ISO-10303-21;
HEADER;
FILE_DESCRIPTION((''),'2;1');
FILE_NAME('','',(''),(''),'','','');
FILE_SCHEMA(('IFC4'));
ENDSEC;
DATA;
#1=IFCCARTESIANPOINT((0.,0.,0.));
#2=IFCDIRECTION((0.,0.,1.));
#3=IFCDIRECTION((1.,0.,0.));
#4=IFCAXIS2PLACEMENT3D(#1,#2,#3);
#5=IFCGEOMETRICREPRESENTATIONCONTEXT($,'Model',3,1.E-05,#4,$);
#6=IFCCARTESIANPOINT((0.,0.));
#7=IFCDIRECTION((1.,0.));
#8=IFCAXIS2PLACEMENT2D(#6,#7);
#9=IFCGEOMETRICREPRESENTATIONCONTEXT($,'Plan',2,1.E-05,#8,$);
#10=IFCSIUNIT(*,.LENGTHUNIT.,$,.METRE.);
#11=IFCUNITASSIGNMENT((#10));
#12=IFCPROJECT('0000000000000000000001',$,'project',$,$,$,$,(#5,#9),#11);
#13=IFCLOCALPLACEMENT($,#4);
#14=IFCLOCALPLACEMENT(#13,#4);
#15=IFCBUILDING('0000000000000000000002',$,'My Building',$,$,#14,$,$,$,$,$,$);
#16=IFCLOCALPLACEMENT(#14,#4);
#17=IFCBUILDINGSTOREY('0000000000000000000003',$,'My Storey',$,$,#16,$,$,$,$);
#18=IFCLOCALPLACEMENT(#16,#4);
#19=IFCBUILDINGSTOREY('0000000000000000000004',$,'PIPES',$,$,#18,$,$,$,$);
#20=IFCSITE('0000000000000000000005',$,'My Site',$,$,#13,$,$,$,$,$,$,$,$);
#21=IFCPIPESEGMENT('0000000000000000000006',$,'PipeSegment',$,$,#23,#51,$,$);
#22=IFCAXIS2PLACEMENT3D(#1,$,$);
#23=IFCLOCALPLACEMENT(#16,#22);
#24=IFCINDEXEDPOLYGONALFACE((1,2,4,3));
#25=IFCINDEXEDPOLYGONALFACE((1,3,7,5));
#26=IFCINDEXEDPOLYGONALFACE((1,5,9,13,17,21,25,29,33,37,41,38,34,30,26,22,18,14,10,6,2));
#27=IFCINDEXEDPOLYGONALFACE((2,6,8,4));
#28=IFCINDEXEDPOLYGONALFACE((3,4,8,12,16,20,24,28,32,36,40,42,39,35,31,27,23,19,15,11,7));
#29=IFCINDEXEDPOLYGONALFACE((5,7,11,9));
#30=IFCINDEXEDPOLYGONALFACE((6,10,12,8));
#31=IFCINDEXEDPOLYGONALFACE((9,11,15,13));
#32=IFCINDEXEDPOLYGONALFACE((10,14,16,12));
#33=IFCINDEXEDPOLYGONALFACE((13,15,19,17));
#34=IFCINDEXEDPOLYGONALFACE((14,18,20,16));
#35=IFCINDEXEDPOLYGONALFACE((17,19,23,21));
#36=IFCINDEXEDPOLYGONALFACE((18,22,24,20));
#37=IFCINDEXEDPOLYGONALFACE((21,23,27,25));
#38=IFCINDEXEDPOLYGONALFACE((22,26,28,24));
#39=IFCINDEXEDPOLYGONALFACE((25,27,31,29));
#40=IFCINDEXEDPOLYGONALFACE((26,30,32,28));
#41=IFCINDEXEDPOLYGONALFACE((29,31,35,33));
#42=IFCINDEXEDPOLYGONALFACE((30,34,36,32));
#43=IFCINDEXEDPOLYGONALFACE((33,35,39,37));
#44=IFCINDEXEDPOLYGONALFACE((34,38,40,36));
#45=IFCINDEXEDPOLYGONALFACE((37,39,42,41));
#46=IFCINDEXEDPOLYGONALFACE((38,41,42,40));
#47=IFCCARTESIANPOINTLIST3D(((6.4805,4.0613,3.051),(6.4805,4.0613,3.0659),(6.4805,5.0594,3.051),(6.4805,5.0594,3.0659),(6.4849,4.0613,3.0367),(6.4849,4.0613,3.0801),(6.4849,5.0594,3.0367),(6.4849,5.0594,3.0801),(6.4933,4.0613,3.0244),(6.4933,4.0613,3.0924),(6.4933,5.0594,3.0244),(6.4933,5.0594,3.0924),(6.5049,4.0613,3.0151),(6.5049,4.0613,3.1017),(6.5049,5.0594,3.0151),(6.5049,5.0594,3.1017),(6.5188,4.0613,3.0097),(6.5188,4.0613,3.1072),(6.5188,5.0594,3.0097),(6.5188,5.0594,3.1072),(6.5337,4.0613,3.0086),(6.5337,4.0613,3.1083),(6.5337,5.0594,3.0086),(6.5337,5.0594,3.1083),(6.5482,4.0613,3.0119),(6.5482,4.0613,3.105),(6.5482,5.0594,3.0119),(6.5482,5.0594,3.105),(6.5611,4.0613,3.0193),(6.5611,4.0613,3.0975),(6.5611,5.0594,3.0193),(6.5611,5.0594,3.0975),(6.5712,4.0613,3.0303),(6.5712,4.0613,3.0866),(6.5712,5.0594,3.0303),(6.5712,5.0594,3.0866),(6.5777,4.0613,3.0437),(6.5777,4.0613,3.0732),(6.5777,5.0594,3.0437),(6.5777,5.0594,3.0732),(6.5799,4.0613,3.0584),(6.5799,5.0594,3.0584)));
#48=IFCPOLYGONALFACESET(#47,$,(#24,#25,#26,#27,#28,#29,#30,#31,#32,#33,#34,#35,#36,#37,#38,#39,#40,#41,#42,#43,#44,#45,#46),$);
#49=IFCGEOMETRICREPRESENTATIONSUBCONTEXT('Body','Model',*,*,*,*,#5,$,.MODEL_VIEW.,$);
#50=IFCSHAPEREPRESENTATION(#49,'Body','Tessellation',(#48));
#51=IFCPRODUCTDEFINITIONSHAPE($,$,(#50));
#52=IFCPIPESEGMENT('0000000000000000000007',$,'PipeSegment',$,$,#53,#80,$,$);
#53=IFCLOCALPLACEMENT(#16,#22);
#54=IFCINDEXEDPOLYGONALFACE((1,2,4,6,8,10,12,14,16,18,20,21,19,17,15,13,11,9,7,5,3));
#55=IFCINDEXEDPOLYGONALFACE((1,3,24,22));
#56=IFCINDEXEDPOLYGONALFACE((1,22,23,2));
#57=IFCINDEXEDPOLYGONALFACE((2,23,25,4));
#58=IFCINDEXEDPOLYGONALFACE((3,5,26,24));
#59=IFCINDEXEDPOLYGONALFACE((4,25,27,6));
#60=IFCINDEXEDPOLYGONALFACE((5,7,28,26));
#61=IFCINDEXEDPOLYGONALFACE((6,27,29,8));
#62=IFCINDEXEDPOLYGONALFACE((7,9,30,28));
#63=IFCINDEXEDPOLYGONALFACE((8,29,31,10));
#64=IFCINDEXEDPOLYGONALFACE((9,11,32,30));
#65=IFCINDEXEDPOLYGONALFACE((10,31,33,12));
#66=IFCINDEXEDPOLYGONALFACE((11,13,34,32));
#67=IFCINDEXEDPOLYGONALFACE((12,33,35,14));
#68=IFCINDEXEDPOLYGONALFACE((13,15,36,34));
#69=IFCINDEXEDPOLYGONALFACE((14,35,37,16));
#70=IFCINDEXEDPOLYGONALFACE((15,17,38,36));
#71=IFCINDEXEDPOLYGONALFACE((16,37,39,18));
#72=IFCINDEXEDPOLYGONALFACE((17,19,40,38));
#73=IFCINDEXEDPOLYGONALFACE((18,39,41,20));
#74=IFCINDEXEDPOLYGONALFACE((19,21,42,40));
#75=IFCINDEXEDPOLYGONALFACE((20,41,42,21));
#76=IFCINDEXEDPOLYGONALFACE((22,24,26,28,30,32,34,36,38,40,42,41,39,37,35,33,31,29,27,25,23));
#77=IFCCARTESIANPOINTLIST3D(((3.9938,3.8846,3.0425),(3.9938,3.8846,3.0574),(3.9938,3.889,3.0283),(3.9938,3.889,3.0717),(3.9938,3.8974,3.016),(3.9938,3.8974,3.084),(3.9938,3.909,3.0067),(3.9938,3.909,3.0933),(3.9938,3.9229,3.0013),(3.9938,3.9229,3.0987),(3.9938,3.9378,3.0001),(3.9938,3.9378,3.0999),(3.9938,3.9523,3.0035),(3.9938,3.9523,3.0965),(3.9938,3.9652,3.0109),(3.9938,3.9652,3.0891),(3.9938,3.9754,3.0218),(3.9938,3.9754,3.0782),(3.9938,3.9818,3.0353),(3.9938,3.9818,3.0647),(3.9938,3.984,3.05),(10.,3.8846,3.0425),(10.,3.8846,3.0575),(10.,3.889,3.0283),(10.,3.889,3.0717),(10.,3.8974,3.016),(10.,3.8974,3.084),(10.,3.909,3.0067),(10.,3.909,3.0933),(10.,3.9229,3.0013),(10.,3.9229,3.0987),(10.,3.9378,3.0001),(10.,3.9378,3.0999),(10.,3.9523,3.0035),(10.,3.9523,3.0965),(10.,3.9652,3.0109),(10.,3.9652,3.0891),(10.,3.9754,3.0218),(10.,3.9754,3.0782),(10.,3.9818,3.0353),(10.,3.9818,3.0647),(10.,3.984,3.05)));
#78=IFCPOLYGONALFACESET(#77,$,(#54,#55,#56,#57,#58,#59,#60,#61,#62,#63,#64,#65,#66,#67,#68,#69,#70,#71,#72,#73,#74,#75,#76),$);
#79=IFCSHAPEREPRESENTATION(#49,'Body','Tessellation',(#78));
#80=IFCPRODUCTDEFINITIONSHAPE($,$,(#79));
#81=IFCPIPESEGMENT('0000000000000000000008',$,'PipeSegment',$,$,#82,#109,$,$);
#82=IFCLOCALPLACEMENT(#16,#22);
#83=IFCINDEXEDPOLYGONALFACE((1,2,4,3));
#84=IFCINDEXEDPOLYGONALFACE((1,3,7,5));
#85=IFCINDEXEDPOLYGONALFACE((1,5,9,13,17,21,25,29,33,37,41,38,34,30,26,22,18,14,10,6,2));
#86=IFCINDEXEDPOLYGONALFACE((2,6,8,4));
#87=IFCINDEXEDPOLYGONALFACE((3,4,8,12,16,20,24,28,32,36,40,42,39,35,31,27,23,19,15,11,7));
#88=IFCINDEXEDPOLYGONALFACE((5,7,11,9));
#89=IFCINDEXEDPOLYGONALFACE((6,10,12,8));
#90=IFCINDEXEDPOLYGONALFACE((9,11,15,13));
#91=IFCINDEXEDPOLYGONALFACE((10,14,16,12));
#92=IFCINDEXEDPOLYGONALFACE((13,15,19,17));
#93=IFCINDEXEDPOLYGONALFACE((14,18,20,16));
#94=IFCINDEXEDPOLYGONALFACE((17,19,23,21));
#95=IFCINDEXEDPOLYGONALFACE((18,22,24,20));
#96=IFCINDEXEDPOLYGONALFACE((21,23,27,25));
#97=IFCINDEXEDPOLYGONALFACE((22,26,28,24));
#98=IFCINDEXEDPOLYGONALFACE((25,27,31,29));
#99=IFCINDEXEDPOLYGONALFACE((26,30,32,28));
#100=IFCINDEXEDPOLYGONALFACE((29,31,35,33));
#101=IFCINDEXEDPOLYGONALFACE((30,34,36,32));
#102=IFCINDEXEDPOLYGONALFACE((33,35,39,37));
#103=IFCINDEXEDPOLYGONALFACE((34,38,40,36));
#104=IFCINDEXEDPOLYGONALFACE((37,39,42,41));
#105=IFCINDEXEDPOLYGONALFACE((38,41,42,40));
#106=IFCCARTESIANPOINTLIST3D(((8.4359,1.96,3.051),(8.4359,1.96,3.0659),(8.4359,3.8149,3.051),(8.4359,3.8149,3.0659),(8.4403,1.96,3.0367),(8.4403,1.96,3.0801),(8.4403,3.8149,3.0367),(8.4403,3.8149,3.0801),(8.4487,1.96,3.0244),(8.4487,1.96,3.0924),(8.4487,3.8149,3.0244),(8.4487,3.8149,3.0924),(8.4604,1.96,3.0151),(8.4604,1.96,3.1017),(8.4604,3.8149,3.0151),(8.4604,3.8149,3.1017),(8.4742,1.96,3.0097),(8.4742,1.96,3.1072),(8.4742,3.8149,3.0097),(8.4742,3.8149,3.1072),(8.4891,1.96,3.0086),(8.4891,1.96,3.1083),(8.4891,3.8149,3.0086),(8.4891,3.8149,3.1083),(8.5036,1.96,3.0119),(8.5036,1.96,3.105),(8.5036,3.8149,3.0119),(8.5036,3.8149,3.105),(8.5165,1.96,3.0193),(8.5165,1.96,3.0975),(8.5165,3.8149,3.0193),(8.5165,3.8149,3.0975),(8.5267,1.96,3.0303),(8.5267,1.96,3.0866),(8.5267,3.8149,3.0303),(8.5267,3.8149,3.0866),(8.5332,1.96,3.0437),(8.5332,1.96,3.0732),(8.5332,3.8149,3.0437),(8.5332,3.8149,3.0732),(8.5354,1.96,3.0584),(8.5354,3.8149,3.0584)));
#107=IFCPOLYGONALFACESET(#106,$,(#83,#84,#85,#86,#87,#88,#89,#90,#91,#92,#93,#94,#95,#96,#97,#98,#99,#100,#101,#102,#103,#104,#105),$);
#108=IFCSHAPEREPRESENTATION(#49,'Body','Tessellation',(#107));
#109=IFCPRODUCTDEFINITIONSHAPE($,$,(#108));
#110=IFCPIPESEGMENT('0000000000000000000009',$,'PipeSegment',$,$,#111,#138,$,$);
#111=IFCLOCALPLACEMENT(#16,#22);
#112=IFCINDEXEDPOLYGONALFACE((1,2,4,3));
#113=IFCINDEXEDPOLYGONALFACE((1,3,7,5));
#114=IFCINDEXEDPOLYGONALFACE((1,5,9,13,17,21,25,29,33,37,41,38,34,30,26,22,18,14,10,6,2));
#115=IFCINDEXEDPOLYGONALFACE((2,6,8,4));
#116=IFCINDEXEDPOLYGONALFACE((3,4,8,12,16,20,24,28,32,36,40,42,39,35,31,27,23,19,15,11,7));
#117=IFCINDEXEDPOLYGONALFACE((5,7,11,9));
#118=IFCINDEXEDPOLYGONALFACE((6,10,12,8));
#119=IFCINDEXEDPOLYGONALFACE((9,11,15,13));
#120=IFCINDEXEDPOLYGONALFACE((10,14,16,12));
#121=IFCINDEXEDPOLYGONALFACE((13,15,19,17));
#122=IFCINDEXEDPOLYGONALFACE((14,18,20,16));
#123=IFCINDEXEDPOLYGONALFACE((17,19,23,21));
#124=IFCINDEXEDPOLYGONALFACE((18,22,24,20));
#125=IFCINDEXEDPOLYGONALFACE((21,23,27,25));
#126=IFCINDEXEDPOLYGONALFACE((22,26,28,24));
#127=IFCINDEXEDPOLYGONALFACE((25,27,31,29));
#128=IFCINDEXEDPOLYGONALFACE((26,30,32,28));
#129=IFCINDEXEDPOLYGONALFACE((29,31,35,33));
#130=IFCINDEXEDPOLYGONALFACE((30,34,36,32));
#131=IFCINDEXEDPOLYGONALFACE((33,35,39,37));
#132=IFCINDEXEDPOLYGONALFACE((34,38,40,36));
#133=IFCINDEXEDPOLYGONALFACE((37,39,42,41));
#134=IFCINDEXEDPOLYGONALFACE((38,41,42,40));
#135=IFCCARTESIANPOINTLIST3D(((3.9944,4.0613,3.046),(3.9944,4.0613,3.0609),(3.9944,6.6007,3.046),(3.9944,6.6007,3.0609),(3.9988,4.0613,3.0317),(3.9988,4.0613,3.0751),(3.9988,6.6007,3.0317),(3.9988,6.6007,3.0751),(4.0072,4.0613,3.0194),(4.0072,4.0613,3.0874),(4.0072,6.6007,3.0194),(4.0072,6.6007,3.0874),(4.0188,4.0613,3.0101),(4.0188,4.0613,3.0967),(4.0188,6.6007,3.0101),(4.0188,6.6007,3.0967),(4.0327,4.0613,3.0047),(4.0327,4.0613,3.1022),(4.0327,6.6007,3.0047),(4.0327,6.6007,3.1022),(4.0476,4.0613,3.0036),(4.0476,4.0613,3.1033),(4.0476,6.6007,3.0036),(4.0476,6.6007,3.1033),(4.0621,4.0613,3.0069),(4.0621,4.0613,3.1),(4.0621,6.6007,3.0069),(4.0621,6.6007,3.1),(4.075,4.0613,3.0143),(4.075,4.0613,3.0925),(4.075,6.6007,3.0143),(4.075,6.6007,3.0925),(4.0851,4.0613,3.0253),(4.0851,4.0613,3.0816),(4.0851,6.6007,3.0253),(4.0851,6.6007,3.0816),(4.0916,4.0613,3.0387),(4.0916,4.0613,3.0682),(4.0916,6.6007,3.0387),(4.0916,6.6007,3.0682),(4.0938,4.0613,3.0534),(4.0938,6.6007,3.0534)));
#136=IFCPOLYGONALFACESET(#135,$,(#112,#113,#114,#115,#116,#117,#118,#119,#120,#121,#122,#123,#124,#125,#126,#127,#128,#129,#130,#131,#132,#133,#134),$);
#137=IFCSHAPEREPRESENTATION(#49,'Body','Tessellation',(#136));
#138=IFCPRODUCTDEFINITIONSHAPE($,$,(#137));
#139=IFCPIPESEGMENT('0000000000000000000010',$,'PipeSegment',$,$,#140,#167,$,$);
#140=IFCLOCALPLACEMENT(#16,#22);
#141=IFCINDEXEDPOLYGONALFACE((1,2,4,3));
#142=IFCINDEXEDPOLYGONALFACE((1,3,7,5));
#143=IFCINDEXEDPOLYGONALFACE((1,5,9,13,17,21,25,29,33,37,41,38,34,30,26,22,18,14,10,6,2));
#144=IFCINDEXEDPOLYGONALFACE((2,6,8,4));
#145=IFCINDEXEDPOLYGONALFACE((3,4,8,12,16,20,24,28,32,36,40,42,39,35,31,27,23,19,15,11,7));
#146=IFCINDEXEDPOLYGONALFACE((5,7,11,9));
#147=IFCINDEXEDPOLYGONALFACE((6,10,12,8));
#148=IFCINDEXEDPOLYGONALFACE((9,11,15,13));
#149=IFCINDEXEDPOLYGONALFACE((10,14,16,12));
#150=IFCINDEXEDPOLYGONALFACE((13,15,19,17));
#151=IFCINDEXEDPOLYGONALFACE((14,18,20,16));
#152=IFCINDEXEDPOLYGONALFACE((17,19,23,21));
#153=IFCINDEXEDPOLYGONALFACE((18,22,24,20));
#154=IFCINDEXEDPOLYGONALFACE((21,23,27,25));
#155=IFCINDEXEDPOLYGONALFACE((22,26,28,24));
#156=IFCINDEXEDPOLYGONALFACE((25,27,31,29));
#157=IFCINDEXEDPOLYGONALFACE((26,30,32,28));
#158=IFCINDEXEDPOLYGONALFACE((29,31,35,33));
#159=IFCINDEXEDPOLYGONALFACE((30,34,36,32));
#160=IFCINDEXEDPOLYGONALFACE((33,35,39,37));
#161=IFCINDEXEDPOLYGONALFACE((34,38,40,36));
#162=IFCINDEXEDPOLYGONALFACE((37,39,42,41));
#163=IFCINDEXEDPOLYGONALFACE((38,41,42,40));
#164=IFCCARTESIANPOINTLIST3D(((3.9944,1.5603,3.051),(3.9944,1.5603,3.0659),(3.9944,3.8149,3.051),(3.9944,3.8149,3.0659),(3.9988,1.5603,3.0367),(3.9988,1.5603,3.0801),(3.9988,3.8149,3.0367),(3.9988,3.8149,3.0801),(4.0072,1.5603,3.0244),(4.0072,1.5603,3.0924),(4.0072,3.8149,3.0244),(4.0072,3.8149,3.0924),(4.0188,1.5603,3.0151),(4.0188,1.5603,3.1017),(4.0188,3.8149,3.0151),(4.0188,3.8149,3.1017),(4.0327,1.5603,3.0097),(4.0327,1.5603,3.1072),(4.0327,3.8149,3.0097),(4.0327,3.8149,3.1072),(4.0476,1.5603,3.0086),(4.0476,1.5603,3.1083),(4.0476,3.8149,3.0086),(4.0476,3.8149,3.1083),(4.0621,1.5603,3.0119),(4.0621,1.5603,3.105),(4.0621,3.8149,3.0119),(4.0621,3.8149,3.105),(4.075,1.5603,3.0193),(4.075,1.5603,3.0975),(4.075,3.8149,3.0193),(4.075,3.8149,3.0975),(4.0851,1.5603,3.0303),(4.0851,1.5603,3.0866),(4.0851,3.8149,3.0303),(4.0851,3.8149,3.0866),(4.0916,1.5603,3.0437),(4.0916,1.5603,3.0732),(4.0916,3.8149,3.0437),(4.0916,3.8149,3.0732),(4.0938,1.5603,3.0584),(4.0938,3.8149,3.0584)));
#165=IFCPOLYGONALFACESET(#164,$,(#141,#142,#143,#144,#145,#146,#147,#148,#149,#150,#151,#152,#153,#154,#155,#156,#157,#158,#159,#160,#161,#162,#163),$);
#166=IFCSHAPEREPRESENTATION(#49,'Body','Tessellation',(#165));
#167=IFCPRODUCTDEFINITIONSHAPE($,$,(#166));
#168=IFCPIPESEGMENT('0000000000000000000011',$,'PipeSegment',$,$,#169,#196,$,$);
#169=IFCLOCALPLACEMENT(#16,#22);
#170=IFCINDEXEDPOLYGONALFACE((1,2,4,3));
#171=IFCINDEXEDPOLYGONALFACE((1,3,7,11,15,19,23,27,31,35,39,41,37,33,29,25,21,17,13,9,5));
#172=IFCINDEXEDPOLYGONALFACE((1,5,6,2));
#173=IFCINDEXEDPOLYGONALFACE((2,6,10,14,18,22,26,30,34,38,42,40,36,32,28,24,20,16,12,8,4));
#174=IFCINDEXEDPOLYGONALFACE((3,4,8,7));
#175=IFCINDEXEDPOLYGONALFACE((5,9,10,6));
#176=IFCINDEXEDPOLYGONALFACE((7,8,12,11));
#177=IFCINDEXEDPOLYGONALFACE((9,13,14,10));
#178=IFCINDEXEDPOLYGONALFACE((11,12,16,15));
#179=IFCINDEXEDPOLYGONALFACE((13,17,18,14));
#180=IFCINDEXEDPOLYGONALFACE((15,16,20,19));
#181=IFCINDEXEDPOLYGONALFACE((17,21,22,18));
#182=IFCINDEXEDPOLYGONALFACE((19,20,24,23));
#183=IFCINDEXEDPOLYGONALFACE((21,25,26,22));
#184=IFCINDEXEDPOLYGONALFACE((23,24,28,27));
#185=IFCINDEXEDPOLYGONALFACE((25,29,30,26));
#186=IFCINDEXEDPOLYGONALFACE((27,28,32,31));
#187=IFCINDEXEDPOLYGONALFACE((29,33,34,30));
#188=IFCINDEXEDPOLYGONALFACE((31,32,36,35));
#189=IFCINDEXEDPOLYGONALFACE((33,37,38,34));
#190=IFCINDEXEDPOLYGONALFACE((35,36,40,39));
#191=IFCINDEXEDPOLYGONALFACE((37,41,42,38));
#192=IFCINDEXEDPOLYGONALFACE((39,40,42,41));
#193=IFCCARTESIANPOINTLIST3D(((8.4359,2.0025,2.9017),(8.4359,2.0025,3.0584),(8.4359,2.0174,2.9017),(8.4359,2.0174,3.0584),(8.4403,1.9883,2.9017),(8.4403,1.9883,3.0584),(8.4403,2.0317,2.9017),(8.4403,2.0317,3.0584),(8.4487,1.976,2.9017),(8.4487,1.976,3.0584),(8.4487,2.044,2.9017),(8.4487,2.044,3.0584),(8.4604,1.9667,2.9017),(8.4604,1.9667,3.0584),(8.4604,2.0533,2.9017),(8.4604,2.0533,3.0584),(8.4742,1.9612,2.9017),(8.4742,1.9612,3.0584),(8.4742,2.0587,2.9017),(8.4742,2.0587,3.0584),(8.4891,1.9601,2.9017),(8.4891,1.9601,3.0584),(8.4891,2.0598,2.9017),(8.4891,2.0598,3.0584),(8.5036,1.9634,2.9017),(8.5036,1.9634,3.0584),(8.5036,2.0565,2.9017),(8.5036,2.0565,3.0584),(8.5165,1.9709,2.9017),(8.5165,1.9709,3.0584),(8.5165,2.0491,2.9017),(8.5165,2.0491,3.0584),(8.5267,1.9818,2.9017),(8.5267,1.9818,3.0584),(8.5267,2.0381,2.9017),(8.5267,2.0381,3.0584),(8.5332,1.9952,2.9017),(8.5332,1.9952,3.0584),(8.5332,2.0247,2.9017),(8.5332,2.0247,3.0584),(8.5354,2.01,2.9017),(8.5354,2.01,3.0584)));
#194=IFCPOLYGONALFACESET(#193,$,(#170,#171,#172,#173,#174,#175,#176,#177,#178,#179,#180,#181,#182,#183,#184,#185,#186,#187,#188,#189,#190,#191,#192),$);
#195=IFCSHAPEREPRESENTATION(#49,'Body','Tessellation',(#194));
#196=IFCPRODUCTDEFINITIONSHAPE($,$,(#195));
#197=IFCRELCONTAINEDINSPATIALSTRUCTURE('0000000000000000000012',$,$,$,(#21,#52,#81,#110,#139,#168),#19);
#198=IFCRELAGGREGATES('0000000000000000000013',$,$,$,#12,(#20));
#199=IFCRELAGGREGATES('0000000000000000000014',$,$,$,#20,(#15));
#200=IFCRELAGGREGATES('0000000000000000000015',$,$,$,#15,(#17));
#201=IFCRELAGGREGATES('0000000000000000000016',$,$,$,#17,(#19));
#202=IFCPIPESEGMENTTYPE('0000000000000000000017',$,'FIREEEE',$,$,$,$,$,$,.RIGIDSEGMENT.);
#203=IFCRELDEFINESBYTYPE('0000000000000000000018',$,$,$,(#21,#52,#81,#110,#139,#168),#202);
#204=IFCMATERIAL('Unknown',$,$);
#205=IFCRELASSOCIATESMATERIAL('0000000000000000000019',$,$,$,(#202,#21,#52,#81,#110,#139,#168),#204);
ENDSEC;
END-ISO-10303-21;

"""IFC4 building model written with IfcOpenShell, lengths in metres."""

from ifc_helpers import new_model, si_unit, frame, origin_with_axes, origin_2d_with_axis, place, context, subcontext, project, spatial, circle, extrude, material, material_profile, profile_set, profile_usage, type_object, element, save


model = new_model("IFC4")

# Units and contexts
model_context = context("Model", 3, precision=1e-05, world=origin_with_axes())
plan_context = context("Plan", 2, precision=1e-05, world=origin_2d_with_axis())
body_context = subcontext(model_context, "Body", "Model", "MODEL_VIEW")
ifc_project = project(units=[si_unit("LENGTHUNIT", "METRE")], contexts=[model_context, plan_context])

# Site, building, storeys
site_placement = place(None, origin_with_axes())
site = spatial("IfcSite", under=ifc_project, at=site_placement, Name="My Site")
building_placement = place(site_placement, origin_with_axes())
building = spatial("IfcBuilding", under=site, at=building_placement, Name="My Building")
storey_1_placement = place(building_placement, origin_with_axes())
storey_1 = spatial("IfcBuildingStorey", under=building, at=storey_1_placement, Name="My Storey")
storey_2_placement = place(storey_1_placement, origin_with_axes())
storey_2 = spatial("IfcBuildingStorey", under=storey_1, at=storey_2_placement, Name="PIPES")

# Pipe segments
ifc_material = material(Name="Unknown")
ifc_material_profile = material_profile(ifc_material, circle(Radius=0.05))
ifc_profile_set = profile_set([ifc_material_profile])
ifc_profile_usage_1 = profile_usage(ifc_profile_set, cardinal=5)
pipe_segment_type = type_object("IfcPipeSegmentType", Name="FIREEEE", PredefinedType="RIGIDSEGMENT", material=ifc_profile_set)
pipe_segment_1_placement = place(storey_2_placement, frame((6.5299, 5.0594, 3.0584), z_axis=(0.0, -1.0, 0.0), x_axis=(1.0, 0.0, 0.0)))
element("IfcPipeSegment", 1, at=pipe_segment_1_placement, inside=storey_2, type_object=pipe_segment_type, material=ifc_profile_usage_1, Name="PipeSegment", context=body_context, shape_type="SweptSolid", body=[
    extrude(circle(Radius=0.05), origin_with_axes(), (0.0, 0.0, 1.0), 0.9981),
])
ifc_profile_usage_2 = profile_usage(ifc_profile_set, cardinal=5)
pipe_segment_2_placement = place(storey_2_placement, frame((3.9938, 3.934, 3.05), z_axis=(1.0, 0.0, 0.000001), x_axis=(0.0, 1.0, 0.0)))
element("IfcPipeSegment", 2, at=pipe_segment_2_placement, inside=storey_2, type_object=pipe_segment_type, material=ifc_profile_usage_2, Name="PipeSegment", context=body_context, shape_type="SweptSolid", body=[
    extrude(circle(Radius=0.05), origin_with_axes(), (0.0, 0.0, 1.0), 6.0062),
])
ifc_profile_usage_3 = profile_usage(ifc_profile_set, cardinal=5)
pipe_segment_3_placement = place(storey_2_placement, frame((8.4854, 3.8149, 3.0584), z_axis=(0.0, -1.0, 0.000001), x_axis=(1.0, 0.0, 0.0)))
element("IfcPipeSegment", 3, at=pipe_segment_3_placement, inside=storey_2, type_object=pipe_segment_type, material=ifc_profile_usage_3, Name="PipeSegment", context=body_context, shape_type="SweptSolid", body=[
    extrude(circle(Radius=0.05), origin_with_axes(), (0.0, 0.0, 1.0), 1.8549),
])
ifc_profile_usage_4 = profile_usage(ifc_profile_set, cardinal=5)
pipe_segment_4_placement = place(storey_2_placement, frame((4.0438, 6.6007, 3.0534), z_axis=(0.0, -1.0, 0.0), x_axis=(1.0, 0.0, 0.0)))
element("IfcPipeSegment", 4, at=pipe_segment_4_placement, inside=storey_2, type_object=pipe_segment_type, material=ifc_profile_usage_4, Name="PipeSegment", context=body_context, shape_type="SweptSolid", body=[
    extrude(circle(Radius=0.05), origin_with_axes(), (0.0, 0.0, 1.0), 2.5394),
])
ifc_profile_usage_5 = profile_usage(ifc_profile_set, cardinal=5)
pipe_segment_5_placement = place(storey_2_placement, frame((4.0438, 3.8149, 3.0584), z_axis=(0.0, -1.0, 0.000001), x_axis=(1.0, 0.0, 0.0)))
element("IfcPipeSegment", 5, at=pipe_segment_5_placement, inside=storey_2, type_object=pipe_segment_type, material=ifc_profile_usage_5, Name="PipeSegment", context=body_context, shape_type="SweptSolid", body=[
    extrude(circle(Radius=0.05), origin_with_axes(), (0.0, 0.0, 1.0), 2.2546),
])
ifc_profile_usage_6 = profile_usage(ifc_profile_set, cardinal=5)
pipe_segment_6_placement = place(storey_2_placement, frame((8.4854, 2.01, 3.0584), z_axis=(0.0, 0.0, -1.0), x_axis=(1.0, 0.0, 0.0)))
element("IfcPipeSegment", 6, at=pipe_segment_6_placement, inside=storey_2, type_object=pipe_segment_type, material=ifc_profile_usage_6, Name="PipeSegment", context=body_context, shape_type="SweptSolid", body=[
    extrude(circle(Radius=0.05), origin_with_axes(), (0.0, 0.0, 1.0), 0.1567),
])

save(model, "model.ifc")
